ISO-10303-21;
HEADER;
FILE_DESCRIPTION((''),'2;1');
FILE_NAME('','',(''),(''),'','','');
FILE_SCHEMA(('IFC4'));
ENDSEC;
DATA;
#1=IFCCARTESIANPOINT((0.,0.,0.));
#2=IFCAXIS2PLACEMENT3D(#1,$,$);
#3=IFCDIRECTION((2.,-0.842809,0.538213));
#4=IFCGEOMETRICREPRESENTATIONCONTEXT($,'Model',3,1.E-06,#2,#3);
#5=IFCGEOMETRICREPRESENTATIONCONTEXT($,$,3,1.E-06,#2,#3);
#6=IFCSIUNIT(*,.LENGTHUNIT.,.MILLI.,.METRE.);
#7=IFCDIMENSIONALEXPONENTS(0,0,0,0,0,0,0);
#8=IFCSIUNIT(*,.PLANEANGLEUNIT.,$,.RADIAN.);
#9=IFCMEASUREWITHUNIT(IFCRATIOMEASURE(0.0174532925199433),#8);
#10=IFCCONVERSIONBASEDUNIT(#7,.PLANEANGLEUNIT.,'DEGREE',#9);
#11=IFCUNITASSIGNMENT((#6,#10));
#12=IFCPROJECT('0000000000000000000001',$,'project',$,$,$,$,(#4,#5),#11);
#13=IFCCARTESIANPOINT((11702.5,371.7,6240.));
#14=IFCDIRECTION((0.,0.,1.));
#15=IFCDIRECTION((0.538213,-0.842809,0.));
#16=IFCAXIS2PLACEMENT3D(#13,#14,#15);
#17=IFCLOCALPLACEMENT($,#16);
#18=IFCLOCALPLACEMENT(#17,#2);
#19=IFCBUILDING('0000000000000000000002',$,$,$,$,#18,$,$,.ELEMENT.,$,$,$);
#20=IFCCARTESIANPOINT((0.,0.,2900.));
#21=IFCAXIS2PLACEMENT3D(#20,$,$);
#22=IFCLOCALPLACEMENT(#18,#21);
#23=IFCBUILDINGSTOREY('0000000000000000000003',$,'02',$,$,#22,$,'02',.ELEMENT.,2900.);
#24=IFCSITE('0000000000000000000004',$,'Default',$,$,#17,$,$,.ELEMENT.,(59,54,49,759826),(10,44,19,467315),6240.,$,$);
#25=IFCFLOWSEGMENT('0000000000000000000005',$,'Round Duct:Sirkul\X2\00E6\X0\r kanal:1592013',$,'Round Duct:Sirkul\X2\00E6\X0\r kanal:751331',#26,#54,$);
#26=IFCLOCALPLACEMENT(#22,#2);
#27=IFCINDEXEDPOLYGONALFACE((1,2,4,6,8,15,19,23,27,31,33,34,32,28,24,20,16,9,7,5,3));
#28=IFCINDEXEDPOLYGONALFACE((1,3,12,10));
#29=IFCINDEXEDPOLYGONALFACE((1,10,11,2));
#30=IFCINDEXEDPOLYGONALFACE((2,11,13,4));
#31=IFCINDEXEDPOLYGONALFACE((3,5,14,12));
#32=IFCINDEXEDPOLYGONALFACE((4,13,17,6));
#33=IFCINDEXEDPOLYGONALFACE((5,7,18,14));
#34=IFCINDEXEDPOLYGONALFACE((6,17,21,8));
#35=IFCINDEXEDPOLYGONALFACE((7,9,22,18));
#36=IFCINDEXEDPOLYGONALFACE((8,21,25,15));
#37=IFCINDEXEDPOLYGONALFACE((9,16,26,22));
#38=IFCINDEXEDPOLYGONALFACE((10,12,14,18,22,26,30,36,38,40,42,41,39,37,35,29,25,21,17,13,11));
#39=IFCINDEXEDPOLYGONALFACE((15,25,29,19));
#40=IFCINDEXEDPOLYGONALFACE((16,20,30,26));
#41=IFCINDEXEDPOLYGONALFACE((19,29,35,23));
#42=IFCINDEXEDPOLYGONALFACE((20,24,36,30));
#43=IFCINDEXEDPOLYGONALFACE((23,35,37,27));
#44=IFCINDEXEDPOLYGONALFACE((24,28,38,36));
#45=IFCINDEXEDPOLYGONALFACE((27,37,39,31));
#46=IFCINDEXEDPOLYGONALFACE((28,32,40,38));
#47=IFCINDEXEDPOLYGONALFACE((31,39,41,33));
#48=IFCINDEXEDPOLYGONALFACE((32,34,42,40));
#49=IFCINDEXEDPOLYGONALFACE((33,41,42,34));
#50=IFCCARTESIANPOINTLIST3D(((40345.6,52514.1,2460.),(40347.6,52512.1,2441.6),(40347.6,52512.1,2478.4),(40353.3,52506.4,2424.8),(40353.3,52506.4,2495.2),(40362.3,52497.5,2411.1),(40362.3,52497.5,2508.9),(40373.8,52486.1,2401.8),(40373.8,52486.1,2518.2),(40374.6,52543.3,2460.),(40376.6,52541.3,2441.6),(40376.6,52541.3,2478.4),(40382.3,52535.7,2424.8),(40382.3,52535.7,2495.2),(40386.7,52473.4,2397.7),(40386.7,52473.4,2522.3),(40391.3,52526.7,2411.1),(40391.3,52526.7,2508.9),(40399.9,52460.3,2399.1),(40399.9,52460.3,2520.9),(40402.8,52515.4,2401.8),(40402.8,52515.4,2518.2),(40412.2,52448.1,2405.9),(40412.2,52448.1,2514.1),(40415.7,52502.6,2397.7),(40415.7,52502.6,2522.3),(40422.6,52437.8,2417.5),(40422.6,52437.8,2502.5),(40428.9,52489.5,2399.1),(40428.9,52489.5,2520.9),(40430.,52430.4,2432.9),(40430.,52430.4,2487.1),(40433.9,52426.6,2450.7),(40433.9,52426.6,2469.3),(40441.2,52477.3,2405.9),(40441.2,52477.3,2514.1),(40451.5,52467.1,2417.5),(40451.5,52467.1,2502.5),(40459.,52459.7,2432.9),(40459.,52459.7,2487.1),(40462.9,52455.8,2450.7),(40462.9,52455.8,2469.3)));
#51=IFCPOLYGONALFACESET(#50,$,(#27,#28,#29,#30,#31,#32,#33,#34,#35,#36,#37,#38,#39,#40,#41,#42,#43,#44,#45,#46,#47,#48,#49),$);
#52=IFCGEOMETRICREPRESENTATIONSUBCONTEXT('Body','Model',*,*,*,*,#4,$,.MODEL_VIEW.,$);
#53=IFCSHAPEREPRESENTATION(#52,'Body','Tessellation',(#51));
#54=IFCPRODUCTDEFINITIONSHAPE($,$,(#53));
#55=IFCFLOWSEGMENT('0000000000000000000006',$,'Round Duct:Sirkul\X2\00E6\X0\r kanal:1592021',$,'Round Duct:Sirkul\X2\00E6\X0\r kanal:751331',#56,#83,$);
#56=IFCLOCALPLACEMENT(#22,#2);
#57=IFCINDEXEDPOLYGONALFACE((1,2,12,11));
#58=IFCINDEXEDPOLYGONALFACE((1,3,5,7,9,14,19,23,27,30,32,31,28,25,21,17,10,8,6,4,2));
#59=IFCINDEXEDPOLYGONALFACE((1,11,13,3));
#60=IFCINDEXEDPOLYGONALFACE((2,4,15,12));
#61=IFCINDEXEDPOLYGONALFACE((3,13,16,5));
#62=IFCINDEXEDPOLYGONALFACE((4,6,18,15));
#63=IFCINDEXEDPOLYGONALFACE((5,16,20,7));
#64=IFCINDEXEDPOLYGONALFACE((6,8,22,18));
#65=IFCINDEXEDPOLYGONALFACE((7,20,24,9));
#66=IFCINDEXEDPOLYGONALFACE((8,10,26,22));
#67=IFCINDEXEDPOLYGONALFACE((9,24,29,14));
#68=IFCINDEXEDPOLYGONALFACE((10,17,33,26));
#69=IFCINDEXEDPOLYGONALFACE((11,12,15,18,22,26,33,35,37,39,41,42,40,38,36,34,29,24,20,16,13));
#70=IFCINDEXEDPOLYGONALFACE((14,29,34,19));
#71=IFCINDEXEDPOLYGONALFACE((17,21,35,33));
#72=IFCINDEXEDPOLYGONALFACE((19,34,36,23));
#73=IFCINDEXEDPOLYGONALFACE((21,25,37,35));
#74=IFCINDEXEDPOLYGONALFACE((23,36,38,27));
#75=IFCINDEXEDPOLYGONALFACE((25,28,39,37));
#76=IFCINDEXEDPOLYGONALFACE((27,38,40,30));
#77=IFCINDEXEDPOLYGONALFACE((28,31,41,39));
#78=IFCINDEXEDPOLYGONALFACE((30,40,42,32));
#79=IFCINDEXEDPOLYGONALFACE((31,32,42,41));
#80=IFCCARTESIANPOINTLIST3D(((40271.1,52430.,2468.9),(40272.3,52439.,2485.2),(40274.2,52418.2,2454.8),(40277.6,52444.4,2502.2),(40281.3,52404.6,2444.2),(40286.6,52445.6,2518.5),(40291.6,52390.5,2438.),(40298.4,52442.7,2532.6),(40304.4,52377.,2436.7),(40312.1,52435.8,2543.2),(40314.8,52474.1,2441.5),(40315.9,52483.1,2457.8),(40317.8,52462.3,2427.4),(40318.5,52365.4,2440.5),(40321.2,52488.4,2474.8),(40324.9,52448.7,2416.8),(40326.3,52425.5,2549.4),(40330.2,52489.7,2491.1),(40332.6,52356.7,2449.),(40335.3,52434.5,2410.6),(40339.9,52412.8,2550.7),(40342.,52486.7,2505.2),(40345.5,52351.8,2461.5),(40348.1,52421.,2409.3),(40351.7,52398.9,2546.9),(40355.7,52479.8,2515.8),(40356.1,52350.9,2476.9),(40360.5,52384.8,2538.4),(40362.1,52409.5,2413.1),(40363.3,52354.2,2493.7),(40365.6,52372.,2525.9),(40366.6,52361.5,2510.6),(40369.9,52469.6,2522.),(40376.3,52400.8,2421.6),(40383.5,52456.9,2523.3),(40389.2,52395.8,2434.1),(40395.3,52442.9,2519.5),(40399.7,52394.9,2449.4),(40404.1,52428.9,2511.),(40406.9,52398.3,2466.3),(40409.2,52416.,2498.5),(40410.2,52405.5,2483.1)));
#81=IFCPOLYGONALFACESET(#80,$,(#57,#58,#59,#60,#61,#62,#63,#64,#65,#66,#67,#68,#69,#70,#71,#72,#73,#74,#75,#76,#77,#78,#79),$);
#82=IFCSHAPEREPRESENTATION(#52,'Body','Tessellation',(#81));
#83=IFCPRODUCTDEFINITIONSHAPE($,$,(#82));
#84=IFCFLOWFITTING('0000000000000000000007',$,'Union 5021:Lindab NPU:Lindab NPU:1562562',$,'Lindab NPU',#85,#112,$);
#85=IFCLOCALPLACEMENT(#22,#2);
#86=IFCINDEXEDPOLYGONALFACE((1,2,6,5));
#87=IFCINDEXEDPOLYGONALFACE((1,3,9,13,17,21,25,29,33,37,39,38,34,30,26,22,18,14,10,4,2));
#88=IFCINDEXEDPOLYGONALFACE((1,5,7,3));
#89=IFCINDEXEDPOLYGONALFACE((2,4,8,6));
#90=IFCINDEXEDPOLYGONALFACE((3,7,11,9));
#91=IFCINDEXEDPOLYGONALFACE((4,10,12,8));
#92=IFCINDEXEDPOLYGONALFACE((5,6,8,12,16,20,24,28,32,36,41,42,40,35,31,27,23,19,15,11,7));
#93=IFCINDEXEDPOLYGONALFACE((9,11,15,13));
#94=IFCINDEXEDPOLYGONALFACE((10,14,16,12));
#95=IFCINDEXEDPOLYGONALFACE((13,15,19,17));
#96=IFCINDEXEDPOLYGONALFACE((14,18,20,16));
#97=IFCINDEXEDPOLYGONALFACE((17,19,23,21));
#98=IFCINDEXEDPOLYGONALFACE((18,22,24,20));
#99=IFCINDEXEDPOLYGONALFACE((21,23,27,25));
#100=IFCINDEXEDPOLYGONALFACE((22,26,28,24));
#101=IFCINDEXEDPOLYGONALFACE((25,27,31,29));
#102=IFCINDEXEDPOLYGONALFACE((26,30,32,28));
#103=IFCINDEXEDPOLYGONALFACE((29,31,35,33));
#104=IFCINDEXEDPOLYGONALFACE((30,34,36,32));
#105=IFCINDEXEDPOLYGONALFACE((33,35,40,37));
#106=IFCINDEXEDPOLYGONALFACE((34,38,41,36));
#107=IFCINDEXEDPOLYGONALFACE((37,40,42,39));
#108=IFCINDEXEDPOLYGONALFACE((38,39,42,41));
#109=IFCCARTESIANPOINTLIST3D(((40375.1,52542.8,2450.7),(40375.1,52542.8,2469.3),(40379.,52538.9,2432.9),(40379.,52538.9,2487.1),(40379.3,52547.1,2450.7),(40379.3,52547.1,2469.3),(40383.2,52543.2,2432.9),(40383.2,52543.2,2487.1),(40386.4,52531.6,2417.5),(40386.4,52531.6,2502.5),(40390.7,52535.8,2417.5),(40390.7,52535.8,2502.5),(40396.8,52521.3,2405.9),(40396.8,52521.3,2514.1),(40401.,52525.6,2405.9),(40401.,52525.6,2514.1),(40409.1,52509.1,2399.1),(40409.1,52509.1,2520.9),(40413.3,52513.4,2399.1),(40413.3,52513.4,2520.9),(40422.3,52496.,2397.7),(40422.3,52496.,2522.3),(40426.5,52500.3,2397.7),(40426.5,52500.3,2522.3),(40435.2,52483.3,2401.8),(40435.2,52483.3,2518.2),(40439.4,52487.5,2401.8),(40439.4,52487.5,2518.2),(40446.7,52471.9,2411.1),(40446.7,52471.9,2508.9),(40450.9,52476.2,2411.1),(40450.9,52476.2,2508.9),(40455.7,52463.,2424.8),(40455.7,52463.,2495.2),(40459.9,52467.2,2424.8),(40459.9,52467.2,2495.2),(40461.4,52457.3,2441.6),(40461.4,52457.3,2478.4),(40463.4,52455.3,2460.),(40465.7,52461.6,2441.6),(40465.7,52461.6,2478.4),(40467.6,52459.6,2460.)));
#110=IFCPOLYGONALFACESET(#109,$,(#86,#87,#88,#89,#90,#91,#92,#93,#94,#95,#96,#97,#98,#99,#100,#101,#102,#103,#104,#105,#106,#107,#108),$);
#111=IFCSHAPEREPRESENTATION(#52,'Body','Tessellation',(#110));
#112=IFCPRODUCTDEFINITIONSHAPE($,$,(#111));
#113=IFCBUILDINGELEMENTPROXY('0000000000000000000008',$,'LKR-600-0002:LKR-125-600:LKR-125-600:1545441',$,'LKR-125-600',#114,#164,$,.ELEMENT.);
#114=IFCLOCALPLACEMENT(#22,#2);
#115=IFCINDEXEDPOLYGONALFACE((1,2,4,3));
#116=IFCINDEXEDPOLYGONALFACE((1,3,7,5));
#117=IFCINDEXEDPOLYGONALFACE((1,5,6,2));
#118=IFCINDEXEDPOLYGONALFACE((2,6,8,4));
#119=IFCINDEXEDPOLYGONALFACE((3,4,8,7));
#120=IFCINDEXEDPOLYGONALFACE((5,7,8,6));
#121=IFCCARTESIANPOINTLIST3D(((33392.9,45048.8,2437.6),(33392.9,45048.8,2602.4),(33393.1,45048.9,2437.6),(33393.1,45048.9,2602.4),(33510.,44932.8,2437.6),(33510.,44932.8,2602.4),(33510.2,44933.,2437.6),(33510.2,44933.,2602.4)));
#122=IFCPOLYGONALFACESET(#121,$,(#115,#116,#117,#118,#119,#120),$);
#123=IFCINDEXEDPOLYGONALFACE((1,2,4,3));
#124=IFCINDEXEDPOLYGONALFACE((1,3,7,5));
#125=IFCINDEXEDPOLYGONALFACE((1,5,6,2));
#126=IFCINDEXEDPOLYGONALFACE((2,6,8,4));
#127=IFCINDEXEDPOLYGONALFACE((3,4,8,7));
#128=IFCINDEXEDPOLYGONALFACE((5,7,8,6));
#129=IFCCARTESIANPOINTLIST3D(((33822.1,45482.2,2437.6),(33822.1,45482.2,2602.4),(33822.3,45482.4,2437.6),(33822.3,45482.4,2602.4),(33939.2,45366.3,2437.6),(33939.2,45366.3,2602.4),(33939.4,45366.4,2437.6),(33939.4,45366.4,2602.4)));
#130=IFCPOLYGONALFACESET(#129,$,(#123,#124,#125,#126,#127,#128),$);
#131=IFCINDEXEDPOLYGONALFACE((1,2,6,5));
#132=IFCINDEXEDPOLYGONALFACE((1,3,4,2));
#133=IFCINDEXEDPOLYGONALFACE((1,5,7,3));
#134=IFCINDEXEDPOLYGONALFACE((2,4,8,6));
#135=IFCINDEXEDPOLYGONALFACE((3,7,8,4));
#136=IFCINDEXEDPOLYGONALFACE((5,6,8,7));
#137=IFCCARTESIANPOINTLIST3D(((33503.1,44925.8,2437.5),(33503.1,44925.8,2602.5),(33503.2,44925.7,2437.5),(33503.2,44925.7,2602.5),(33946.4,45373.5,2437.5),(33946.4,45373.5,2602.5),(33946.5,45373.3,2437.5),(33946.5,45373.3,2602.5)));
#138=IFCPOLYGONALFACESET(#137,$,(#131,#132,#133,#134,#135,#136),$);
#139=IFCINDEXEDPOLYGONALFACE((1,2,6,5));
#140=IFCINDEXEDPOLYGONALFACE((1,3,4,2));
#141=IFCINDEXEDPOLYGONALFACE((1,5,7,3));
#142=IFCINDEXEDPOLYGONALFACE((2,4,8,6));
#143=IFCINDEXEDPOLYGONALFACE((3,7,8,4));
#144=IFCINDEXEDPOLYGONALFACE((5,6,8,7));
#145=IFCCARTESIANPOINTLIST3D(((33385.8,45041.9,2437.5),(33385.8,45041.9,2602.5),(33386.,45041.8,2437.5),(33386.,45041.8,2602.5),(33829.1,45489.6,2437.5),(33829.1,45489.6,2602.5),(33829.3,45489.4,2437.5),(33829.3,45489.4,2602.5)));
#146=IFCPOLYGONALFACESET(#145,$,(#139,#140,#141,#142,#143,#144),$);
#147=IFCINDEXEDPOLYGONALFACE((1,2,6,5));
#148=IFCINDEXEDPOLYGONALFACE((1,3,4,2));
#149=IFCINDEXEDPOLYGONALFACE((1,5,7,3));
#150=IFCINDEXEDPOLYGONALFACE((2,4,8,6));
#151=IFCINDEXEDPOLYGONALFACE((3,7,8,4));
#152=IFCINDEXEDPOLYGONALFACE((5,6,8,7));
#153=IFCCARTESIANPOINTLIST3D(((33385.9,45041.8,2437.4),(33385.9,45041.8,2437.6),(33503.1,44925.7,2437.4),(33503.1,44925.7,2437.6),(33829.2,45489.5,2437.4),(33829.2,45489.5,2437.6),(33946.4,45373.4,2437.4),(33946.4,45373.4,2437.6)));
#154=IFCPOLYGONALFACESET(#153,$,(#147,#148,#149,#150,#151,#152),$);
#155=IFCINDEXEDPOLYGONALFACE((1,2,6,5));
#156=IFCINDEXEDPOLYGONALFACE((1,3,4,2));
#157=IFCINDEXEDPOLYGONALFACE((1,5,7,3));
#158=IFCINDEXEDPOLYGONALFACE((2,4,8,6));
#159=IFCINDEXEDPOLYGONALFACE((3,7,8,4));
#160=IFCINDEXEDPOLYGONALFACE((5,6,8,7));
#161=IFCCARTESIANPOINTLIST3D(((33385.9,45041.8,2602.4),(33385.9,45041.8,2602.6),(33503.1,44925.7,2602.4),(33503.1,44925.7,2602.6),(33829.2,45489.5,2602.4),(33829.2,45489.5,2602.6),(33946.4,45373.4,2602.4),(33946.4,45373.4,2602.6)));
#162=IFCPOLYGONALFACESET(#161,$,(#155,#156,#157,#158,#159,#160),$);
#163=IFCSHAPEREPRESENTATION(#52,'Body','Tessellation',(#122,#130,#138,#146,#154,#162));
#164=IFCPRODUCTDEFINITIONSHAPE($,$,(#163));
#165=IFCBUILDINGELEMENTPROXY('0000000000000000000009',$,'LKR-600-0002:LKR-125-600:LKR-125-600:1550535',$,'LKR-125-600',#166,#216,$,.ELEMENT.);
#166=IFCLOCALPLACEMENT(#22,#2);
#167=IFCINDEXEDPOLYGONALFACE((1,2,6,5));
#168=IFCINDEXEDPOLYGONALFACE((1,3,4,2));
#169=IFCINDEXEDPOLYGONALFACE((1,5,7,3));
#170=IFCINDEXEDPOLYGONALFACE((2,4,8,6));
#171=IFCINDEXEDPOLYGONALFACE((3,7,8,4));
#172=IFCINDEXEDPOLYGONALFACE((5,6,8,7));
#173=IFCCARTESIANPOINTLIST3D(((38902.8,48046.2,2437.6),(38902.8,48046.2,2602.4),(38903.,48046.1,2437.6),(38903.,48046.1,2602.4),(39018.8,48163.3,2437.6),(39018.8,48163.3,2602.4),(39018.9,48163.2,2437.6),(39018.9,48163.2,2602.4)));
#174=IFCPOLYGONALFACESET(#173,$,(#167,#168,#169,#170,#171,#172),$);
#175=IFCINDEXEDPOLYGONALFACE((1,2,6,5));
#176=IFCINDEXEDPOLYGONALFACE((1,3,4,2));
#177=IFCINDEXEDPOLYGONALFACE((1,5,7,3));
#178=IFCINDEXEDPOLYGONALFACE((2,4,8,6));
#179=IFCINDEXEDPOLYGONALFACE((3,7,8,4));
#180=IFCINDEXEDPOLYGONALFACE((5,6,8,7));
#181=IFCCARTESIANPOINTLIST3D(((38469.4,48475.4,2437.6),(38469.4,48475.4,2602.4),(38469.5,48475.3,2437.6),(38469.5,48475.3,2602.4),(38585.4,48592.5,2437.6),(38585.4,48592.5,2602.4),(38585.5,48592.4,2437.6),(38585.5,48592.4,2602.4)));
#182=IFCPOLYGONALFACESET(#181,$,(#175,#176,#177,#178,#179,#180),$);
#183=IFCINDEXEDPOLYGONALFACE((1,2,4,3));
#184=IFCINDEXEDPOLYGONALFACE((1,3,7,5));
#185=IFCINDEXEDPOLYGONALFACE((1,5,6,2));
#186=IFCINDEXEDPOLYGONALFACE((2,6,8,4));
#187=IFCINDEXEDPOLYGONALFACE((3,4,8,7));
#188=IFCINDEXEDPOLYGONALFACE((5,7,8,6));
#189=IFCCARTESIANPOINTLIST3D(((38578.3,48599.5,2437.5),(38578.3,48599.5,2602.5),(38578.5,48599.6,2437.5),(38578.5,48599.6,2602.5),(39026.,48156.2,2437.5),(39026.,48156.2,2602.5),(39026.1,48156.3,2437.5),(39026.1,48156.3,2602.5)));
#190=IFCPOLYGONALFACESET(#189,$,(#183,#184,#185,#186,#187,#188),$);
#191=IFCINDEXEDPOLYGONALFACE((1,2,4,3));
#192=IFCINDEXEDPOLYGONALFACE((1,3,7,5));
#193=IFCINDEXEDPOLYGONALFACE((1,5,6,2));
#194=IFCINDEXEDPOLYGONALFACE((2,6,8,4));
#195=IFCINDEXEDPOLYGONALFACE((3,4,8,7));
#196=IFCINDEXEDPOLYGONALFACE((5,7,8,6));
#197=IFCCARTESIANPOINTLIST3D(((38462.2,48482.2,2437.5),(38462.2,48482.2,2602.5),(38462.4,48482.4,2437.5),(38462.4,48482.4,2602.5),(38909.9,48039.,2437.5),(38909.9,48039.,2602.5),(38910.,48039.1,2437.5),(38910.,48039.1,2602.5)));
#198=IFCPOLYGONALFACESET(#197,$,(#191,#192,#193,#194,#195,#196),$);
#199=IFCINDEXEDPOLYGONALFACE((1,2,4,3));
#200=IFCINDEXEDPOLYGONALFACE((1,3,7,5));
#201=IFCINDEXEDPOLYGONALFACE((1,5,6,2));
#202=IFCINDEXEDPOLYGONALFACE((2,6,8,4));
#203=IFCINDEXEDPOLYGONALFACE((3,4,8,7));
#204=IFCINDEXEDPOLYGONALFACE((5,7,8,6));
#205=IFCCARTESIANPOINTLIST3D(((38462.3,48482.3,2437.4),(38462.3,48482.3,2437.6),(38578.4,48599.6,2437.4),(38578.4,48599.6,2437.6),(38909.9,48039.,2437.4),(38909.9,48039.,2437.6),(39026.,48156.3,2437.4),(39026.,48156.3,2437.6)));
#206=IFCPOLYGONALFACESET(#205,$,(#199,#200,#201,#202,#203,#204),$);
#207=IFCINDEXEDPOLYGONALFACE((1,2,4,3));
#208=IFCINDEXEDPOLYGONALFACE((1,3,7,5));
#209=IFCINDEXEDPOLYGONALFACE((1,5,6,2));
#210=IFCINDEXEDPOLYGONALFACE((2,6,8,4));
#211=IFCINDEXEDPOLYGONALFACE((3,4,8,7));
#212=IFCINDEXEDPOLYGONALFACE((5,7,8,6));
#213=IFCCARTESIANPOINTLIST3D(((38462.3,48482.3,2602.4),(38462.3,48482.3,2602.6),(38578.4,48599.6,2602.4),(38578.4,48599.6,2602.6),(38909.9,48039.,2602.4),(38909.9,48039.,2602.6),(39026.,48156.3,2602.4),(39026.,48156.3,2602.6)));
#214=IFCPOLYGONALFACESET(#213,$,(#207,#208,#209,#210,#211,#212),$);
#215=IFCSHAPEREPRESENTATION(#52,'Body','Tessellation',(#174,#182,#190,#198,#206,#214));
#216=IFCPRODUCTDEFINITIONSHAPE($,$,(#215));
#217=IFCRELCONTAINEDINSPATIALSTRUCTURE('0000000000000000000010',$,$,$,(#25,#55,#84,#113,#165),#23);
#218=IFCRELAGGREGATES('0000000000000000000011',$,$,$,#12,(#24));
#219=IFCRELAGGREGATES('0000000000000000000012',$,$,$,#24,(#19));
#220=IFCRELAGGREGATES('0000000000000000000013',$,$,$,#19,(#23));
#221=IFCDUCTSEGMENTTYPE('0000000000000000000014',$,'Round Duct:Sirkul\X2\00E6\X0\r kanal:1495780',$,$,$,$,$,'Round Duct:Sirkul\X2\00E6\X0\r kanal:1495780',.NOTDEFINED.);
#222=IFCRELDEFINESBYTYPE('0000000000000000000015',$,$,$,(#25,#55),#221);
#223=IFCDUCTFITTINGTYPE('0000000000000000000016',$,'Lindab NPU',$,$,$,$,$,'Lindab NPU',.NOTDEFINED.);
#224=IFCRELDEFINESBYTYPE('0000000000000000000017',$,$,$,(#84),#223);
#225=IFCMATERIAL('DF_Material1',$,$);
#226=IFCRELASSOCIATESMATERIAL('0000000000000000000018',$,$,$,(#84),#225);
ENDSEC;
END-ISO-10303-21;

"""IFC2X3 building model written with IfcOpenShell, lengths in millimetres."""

from ifc_helpers import new_model, entity, si_unit, converted_unit, direction, frame, frame_2d, origin, origin_2d_with_axis, place, context, subcontext, project, spatial, rectangle, circle, extrude, source, transform, mapped, material, type_object, type_shapes, element, save


model = new_model("IFC2X3")

# Units and contexts
model_context = context("Model", 3, precision=1e-06, world=origin(), true_north=direction((2.0, -0.842809, 0.538213)))
context_of_model = context(None, 3, precision=1e-06, world=origin(), true_north=direction((2.0, -0.842809, 0.538213)))
body_context = subcontext(model_context, "Body", "Model", "MODEL_VIEW")
ifc_project = project(units=[si_unit("LENGTHUNIT", "METRE", prefix="MILLI"), converted_unit("PLANEANGLEUNIT", "DEGREE", entity("IfcRatioMeasure", 0.0174532925199433), si_unit("PLANEANGLEUNIT", "RADIAN"), dimensions=[0, 0, 0, 0, 0, 0, 0])], contexts=[model_context, context_of_model])

# Site, building, storey
site_placement = place(None, frame((11702.5, 371.7, 6240.0), z_axis=(0.0, 0.0, 1.0), x_axis=(0.538213, -0.842809, 0.0)))
site = spatial("IfcSite", under=ifc_project, at=site_placement, Name="Default", CompositionType="ELEMENT", RefLatitude=(59, 54, 49, 759826), RefLongitude=(10, 44, 19, 467315), RefElevation=6240.0)
building_placement = place(site_placement, origin())
building = spatial("IfcBuilding", under=site, at=building_placement, CompositionType="ELEMENT")
storey_placement = place(building_placement, frame((0.0, 0.0, 2900.0)))
storey = spatial("IfcBuildingStorey", under=building, at=storey_placement, Name="02", LongName="02", CompositionType="ELEMENT", Elevation=2900.0)

# Flow segments
duct_segment_type = type_object("IfcDuctSegmentType", Name="Round Duct:Sirkulær kanal:1495780", ElementType="Round Duct:Sirkulær kanal:1495780", PredefinedType="NOTDEFINED")
flow_segment_1_placement = place(storey_placement, origin())
element("IfcFlowSegment", 1, at=flow_segment_1_placement, inside=storey, type_object=duct_segment_type, Name="Round Duct:Sirkulær kanal:1592013", ObjectType="Round Duct:Sirkulær kanal:751331", context=body_context, shape_type="SweptSolid", body=[
    extrude(circle(Radius=62.5, at=frame_2d((0.0, 0.0), x_axis=(1.0, 0.0))), frame((40390.0, 52470.1, 2460.0), z_axis=(0.703643, 0.710554, 0.0), x_axis=(-0.710554, 0.703643, 0.0)), (0.0, 0.0, 1.0), 41.2),
])
flow_segment_2_placement = place(storey_placement, origin())
element("IfcFlowSegment", 2, at=flow_segment_2_placement, inside=storey, type_object=duct_segment_type, Name="Round Duct:Sirkulær kanal:1592021", ObjectType="Round Duct:Sirkulær kanal:751331", context=body_context, shape_type="SweptSolid", body=[
    extrude(circle(Radius=62.5, at=origin_2d_with_axis()), frame((40318.9, 52398.2, 2493.7), z_axis=(0.64349, 0.649808, -0.404562), x_axis=(0.710553, -0.703644, 0.0)), (0.0, 0.0, 1.0), 67.8),
])

# Flow fitting
ifc_material = material(Name="DF_Material1")
duct_fitting_type = type_object("IfcDuctFittingType", Name="Lindab NPU", ElementType="Lindab NPU", PredefinedType="NOTDEFINED")
shared_shape_1 = source(origin(), body_context, "Body", "SweptSolid", [
    extrude(circle(Radius=62.5, at=frame_2d((0.0, 0.0), x_axis=(1.0, 0.0))), frame((0.0, 0.0, 0.0), z_axis=(1.0, 0.0, 0.0), x_axis=(0.0, 1.0, 0.0)), (0.0, 0.0, 1.0), 6.0),
])
type_shapes(duct_fitting_type, [shared_shape_1])
flow_fitting_placement = place(storey_placement, frame((40423.2, 52503.6, 2460.0), z_axis=(0.0, 0.0, 1.0), x_axis=(-0.703643, -0.710553, 0.0)))
element("IfcFlowFitting", 3, at=flow_fitting_placement, inside=storey, type_object=duct_fitting_type, material=ifc_material, Name="Union 5021:Lindab NPU:Lindab NPU:1562562", ObjectType="Lindab NPU", context=body_context, shape_type="MappedRepresentation", body=[
    mapped(shared_shape_1, transform((0.0, 0.0, 0.0), scale=1.0)),
])

# Building element proxies
shared_shape_2 = source(origin(), body_context, "Body", "SweptSolid", [
    extrude(rectangle(XDim=0.2, YDim=164.8, at=frame_2d((0.0, 0.0), x_axis=(1.0, 0.0))), frame((305.0, 0.0, -82.4)), (0.0, 0.0, 1.0), 164.8),
    extrude(rectangle(XDim=0.2, YDim=164.8, at=frame_2d((0.0, 0.0), x_axis=(1.0, 0.0))), frame((-305.0, 0.0, -82.4)), (0.0, 0.0, 1.0), 164.8),
    extrude(rectangle(XDim=0.2, YDim=630.0, at=frame_2d((0.0, 0.0), x_axis=(1.0, 0.0))), frame((0.0, 82.5, -82.5), z_axis=(0.0, 0.0, 1.0), x_axis=(0.0, 1.0, 0.0)), (0.0, 0.0, 1.0), 165.0),
    extrude(rectangle(XDim=0.2, YDim=630.0, at=frame_2d((0.0, 0.0), x_axis=(1.0, 0.0))), frame((0.0, -82.5, -82.5), z_axis=(0.0, 0.0, 1.0), x_axis=(0.0, 1.0, 0.0)), (0.0, 0.0, 1.0), 165.0),
    extrude(rectangle(XDim=165.0, YDim=630.0, at=frame_2d((0.0, 0.0), x_axis=(1.0, 0.0))), frame((0.0, 0.0, -82.6), z_axis=(0.0, 0.0, 1.0), x_axis=(0.0, -1.0, 0.0)), (0.0, 0.0, 1.0), 0.2),
    extrude(rectangle(XDim=165.0, YDim=630.0, at=frame_2d((0.0, 0.0), x_axis=(1.0, 0.0))), frame((0.0, 0.0, 82.4), z_axis=(0.0, 0.0, 1.0), x_axis=(0.0, -1.0, 0.0)), (0.0, 0.0, 1.0), 0.2),
])
for number, where, z_axis, x_axis, name in (
    (4, (33666.2, 45207.6, 2520.0), (0.0, 0.0, 1.0), (-0.703643, -0.710554, 0.0), "LKR-600-0002:LKR-125-600:LKR-125-600:1545441"),
    (5, (38744.2, 48319.3, 2520.0), (0.0, 0.0, 1.0), (0.710554, -0.703643, 0.0), "LKR-600-0002:LKR-125-600:LKR-125-600:1550535"),
):
    element("IfcBuildingElementProxy", number, at=place(storey_placement, frame(where, z_axis=z_axis, x_axis=x_axis)), inside=storey, Name=name, ObjectType="LKR-125-600", CompositionType="ELEMENT", context=body_context, shape_type="MappedRepresentation", body=[
        mapped(shared_shape_2, transform((0.0, 0.0, 0.0), scale=1.0)),
    ])

save(model, "model.ifc")
